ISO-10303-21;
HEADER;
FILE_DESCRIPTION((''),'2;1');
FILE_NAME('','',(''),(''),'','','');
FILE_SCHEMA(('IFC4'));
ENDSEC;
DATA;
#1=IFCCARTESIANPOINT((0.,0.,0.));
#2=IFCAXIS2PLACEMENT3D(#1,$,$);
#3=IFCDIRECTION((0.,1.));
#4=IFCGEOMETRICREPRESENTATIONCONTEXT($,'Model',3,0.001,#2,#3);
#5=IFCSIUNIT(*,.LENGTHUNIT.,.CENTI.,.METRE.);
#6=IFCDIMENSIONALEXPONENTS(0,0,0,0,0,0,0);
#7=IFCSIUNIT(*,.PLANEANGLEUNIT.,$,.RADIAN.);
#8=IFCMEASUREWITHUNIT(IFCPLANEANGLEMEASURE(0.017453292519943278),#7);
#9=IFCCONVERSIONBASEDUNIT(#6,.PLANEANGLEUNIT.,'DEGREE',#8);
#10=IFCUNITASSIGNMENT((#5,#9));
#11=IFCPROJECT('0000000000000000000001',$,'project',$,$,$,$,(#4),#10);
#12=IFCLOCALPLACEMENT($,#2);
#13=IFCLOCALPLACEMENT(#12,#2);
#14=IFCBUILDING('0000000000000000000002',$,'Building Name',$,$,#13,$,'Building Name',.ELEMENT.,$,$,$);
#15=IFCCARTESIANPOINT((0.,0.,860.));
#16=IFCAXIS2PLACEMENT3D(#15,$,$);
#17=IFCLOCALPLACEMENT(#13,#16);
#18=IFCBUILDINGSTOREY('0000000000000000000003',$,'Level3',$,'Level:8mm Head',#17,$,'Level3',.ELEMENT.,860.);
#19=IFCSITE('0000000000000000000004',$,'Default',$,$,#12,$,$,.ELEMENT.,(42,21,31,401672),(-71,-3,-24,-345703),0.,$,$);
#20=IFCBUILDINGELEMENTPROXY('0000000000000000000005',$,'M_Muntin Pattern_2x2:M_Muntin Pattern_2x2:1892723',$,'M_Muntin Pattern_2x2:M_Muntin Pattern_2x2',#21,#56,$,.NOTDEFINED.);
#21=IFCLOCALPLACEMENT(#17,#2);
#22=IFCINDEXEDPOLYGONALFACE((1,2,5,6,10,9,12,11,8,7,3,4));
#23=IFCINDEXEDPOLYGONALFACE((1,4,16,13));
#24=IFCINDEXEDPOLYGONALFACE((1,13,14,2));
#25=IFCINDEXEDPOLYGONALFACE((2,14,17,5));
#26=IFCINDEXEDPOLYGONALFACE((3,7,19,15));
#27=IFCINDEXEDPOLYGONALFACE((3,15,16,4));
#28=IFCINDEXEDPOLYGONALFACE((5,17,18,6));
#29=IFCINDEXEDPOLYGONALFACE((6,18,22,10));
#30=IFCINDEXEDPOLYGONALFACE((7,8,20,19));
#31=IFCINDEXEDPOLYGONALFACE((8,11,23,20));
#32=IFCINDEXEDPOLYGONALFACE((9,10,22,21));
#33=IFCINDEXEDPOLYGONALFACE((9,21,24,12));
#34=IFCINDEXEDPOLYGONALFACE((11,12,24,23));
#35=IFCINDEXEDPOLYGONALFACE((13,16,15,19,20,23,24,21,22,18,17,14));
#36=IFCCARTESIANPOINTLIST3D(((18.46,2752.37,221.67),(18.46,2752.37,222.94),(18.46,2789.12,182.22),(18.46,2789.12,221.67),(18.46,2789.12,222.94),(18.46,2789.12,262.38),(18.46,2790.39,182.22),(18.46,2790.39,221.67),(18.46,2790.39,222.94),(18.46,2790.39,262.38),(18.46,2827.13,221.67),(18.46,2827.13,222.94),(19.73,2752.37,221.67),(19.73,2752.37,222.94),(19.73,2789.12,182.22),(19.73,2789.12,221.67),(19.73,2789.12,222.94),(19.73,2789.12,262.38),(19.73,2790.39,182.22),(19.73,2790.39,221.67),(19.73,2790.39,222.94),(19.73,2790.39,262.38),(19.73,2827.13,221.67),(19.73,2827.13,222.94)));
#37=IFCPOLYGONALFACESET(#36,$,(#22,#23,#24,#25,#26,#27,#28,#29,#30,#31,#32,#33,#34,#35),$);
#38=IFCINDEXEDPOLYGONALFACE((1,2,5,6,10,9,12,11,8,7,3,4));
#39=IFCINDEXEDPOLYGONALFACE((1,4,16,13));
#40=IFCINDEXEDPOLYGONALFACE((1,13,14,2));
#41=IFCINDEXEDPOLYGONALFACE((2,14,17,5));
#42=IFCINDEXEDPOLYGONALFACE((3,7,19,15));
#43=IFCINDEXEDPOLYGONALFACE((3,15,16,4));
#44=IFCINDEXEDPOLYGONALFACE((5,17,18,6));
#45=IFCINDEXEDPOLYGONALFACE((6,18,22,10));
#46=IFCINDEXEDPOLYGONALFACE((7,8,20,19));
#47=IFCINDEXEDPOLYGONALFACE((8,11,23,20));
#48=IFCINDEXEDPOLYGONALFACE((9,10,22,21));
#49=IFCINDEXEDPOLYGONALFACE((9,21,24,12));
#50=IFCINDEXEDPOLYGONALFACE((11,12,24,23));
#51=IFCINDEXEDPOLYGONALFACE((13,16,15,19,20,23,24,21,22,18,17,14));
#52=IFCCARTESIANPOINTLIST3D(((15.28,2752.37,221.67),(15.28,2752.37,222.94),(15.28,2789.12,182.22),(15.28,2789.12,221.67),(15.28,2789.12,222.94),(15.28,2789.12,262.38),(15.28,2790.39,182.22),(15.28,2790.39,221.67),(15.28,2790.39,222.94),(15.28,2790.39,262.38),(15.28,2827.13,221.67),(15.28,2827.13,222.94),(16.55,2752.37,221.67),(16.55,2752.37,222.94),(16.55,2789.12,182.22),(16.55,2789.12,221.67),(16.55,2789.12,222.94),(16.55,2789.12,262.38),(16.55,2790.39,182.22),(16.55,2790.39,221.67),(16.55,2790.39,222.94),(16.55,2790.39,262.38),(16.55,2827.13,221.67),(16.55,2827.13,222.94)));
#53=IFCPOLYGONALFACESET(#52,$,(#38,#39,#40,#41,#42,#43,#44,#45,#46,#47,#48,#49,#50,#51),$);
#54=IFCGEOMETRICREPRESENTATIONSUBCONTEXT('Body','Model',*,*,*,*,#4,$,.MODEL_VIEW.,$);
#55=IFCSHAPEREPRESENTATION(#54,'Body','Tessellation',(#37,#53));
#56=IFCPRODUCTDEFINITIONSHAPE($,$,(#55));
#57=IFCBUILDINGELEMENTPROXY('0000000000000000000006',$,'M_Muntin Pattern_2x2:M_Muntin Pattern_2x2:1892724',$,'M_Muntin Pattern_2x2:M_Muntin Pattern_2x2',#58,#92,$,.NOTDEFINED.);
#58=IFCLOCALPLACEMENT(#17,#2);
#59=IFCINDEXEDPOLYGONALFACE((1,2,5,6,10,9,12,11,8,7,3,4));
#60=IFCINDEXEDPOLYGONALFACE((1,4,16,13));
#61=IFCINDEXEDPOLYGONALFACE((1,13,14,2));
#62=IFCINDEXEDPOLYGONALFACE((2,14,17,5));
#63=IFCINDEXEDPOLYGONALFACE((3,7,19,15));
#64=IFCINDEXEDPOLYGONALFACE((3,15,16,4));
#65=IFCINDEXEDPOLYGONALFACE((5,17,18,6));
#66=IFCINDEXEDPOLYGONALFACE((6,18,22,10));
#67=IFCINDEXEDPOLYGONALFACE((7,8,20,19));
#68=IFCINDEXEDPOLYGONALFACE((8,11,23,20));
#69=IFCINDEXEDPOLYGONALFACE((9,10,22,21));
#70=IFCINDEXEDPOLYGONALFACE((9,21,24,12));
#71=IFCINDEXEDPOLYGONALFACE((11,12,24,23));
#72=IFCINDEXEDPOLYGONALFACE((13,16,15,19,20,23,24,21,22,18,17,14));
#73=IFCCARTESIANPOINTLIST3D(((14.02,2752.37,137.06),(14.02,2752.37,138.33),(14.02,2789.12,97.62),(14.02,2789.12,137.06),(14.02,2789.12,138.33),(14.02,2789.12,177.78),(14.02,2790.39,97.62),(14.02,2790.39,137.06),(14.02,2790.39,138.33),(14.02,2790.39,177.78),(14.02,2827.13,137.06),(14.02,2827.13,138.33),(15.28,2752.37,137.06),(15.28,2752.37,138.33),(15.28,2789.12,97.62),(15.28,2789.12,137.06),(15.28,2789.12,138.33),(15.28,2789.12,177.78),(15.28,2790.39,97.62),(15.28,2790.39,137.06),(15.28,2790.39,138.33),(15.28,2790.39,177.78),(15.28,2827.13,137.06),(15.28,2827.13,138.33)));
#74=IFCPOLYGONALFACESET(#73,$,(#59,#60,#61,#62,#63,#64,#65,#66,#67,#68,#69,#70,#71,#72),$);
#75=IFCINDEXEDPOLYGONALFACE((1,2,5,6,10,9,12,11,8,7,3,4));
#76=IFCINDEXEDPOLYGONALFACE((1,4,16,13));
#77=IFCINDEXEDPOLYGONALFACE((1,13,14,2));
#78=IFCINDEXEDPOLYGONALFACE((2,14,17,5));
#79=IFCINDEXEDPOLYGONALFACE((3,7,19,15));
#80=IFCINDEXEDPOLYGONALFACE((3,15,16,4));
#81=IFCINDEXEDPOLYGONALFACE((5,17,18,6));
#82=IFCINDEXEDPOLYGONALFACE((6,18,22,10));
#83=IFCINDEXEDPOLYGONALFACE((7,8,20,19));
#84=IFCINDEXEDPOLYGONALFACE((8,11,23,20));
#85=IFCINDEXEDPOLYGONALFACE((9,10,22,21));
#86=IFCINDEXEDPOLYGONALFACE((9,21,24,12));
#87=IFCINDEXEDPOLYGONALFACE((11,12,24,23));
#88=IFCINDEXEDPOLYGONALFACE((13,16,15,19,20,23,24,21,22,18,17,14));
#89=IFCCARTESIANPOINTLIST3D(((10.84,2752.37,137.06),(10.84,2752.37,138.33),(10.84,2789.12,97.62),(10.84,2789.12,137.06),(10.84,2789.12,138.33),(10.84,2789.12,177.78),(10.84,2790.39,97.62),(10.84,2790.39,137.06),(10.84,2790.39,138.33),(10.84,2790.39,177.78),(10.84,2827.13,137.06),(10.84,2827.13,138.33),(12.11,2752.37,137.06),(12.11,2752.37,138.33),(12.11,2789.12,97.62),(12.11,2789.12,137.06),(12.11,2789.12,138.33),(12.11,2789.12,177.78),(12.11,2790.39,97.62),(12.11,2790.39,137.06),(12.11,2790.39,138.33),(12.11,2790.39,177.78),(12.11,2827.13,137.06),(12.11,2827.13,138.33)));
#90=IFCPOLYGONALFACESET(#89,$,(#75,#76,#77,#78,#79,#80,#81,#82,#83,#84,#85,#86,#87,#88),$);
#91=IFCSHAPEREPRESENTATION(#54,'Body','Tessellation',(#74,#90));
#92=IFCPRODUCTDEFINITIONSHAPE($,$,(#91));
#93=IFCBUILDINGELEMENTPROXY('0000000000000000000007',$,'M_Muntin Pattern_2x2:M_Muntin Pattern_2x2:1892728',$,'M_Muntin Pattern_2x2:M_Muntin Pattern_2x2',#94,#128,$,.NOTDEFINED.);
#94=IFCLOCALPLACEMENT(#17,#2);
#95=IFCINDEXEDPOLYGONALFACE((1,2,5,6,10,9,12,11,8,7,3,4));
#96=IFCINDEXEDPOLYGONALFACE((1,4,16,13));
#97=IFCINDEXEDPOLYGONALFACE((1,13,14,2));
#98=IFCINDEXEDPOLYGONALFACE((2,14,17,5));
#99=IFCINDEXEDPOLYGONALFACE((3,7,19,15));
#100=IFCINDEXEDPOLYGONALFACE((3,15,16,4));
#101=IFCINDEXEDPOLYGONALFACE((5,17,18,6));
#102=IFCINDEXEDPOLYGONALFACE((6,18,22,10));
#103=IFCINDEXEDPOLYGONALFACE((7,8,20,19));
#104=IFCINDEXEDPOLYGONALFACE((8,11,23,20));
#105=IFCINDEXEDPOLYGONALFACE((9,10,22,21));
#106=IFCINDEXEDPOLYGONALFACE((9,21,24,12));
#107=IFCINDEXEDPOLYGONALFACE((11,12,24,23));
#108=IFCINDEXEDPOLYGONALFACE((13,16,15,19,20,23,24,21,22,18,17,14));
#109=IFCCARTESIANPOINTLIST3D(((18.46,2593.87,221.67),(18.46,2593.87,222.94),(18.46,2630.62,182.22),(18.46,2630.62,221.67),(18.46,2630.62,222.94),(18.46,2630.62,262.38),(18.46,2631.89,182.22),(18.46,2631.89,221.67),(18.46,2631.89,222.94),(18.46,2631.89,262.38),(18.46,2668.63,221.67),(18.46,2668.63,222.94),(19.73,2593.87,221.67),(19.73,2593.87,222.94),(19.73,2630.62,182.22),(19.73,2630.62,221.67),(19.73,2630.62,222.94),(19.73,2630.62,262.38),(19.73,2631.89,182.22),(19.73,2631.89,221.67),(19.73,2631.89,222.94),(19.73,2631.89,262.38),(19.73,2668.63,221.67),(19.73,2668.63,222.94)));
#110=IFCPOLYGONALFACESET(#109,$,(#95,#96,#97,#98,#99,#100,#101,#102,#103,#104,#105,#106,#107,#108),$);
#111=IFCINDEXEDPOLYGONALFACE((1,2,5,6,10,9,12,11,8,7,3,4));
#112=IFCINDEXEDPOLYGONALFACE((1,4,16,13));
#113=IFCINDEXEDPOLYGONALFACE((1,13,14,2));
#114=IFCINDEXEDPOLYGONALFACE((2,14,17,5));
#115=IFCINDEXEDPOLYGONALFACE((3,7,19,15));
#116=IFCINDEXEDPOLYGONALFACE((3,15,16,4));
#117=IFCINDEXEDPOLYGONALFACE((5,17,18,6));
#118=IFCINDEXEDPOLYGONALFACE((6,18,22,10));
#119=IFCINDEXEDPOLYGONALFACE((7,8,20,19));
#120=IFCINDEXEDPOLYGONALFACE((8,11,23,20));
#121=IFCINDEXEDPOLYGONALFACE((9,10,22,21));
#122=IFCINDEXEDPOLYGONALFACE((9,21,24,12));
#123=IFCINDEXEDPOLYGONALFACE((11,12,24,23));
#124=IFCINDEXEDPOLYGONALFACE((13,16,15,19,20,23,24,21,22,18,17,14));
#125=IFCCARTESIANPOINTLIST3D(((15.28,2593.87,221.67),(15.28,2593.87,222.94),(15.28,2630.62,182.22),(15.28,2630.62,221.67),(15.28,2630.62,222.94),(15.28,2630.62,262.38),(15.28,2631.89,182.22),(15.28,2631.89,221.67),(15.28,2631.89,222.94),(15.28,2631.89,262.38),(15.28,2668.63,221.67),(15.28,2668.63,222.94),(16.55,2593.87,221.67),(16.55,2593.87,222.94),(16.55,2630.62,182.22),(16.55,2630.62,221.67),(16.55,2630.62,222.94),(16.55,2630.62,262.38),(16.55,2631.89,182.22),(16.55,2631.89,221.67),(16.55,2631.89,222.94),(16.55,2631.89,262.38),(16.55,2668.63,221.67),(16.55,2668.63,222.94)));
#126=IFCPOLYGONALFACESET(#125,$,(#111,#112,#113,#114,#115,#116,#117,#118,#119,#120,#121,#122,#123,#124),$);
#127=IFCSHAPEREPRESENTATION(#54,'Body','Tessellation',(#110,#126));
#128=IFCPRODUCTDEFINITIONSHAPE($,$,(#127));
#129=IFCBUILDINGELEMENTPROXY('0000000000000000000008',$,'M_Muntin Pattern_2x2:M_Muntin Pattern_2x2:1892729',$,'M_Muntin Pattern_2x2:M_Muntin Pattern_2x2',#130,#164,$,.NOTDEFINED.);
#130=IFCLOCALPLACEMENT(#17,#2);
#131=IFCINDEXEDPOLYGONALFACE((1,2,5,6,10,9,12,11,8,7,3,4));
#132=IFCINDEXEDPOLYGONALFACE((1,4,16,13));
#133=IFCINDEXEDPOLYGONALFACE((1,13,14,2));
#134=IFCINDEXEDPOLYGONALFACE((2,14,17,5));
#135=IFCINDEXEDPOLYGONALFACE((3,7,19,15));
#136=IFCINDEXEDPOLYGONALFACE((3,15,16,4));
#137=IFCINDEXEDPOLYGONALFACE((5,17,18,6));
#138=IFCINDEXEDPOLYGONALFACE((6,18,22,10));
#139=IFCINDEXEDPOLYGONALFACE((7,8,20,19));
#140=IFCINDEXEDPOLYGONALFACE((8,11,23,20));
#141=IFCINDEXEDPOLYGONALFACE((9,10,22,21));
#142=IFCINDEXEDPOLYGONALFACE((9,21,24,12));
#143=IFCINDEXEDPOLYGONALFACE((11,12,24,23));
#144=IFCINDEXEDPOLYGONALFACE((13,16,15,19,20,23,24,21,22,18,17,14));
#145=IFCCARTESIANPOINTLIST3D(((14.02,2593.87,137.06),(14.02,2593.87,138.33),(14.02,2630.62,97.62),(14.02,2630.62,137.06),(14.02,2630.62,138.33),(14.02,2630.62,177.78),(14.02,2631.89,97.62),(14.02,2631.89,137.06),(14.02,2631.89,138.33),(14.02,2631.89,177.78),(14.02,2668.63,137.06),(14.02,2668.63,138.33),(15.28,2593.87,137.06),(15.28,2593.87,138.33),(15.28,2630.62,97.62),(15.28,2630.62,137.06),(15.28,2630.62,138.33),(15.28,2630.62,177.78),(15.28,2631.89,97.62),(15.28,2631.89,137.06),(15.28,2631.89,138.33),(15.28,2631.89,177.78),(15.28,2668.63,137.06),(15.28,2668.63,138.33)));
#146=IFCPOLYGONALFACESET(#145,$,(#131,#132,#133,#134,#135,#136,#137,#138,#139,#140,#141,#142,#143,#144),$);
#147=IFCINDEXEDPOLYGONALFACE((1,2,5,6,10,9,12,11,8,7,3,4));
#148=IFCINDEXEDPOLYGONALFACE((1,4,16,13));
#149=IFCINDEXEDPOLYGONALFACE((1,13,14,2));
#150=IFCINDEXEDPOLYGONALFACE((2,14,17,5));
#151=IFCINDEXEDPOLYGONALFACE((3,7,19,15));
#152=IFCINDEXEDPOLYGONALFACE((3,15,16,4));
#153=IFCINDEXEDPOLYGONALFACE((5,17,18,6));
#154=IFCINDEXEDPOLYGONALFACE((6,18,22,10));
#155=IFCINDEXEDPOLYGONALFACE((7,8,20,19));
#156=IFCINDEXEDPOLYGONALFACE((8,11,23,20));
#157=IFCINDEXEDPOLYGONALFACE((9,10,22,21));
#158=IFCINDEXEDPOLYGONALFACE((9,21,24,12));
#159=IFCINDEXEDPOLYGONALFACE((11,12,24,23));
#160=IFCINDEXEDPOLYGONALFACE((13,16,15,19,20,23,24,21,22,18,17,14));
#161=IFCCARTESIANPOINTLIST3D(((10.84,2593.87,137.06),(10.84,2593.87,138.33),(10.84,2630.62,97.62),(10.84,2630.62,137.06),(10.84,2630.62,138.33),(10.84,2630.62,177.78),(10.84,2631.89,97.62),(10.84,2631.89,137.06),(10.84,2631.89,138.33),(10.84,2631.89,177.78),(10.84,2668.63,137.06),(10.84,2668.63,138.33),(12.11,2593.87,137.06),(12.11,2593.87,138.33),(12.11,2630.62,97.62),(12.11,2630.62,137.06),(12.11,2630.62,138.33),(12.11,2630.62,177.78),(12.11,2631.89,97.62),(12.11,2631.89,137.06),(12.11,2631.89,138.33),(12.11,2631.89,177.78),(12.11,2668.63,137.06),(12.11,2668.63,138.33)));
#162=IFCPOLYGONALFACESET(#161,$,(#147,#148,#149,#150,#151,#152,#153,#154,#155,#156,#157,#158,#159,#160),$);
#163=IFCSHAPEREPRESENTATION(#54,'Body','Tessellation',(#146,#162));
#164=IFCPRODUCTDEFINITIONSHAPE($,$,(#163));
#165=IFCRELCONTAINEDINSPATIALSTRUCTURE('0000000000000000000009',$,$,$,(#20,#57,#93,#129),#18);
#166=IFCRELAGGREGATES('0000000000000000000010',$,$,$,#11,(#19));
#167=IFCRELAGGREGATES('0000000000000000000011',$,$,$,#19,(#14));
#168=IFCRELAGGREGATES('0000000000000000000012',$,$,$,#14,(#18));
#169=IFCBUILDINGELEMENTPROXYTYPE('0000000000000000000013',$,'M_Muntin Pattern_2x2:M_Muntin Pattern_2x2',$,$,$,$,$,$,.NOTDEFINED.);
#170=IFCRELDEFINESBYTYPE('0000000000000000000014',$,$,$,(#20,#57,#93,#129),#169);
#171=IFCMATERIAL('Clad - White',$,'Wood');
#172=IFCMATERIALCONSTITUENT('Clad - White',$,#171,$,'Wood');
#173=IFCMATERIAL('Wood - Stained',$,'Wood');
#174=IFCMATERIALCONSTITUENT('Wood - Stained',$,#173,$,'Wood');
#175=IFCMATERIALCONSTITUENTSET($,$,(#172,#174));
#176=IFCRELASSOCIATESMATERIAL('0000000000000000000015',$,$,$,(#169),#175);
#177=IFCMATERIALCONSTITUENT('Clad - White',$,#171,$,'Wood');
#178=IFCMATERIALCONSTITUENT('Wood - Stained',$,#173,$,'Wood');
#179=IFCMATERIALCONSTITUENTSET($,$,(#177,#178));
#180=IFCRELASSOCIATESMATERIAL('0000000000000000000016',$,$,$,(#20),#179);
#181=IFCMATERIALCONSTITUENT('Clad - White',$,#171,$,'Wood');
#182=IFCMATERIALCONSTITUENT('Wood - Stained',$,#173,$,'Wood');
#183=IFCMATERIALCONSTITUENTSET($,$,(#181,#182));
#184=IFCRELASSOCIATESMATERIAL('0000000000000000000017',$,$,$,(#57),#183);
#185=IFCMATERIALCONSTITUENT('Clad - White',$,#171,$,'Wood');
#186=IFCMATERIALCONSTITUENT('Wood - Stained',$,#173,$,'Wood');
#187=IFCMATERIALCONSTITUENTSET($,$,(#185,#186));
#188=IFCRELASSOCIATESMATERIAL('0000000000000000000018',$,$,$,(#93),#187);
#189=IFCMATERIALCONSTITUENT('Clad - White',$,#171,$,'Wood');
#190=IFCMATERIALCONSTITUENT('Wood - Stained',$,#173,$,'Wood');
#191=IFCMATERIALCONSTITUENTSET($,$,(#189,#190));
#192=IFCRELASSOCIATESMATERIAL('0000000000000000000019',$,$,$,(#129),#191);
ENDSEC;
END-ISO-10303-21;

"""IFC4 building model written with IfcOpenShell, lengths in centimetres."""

from ifc_helpers import new_model, entity, si_unit, converted_unit, direction, frame, origin, place, context, subcontext, project, spatial, indexed_curve, outline, extrude, source, transform, mapped, material, constituent, constituent_set, type_object, type_shapes, element, save


model = new_model("IFC4")

# Units and contexts
model_context = context("Model", 3, precision=0.001, world=origin(), true_north=direction((0.0, 1.0)))
body_context = subcontext(model_context, "Body", "Model", "MODEL_VIEW")
ifc_project = project(units=[si_unit("LENGTHUNIT", "METRE", prefix="CENTI"), converted_unit("PLANEANGLEUNIT", "DEGREE", entity("IfcPlaneAngleMeasure", 0.017453292519943278), si_unit("PLANEANGLEUNIT", "RADIAN"), dimensions=[0, 0, 0, 0, 0, 0, 0])], contexts=[model_context])

# Site, building, storey
site_placement = place(None, origin())
site = spatial("IfcSite", under=ifc_project, at=site_placement, Name="Default", CompositionType="ELEMENT", RefLatitude=(42, 21, 31, 401672), RefLongitude=(-71, -3, -24, -345703), RefElevation=0.0)
building_placement = place(site_placement, origin())
building = spatial("IfcBuilding", under=site, at=building_placement, Name="Building Name", LongName="Building Name", CompositionType="ELEMENT")
storey_placement = place(building_placement, frame((0.0, 0.0, 860.0)))
storey = spatial("IfcBuildingStorey", under=building, at=storey_placement, Name="Level3", ObjectType="Level:8mm Head", LongName="Level3", CompositionType="ELEMENT", Elevation=860.0)

# Shared definitions
ifc_material_1 = material(Name="Wood - Stained", Category="Wood")

# Building element proxies
ifc_material_2 = material(Name="Clad - White", Category="Wood")
ifc_constituent_1 = constituent(ifc_material_2, Name="Clad - White", Category="Wood")
ifc_constituent_2 = constituent(ifc_material_1, Name="Wood - Stained", Category="Wood")
ifc_constituent_set_1 = constituent_set(constituents=[ifc_constituent_1, ifc_constituent_2])
ifc_constituent_3 = constituent(ifc_material_2, Name="Clad - White", Category="Wood")
ifc_constituent_4 = constituent(ifc_material_1, Name="Wood - Stained", Category="Wood")
ifc_constituent_set_2 = constituent_set(constituents=[ifc_constituent_3, ifc_constituent_4])
building_element_proxy_type_1 = type_object("IfcBuildingElementProxyType", Name="M_Muntin Pattern_2x2:M_Muntin Pattern_2x2", PredefinedType="NOTDEFINED", material=ifc_constituent_set_2)
shared_shape_1 = source(origin(), body_context, "Body", "SweptSolid", [
    extrude(outline(indexed_curve([(0.64, -0.64), (40.08, -0.64), (40.08, 0.63), (0.64, 0.63), (0.64, 37.38), (-0.63, 37.38), (-0.63, 0.63), (-40.08, 0.63), (-40.08, -0.64), (-0.63, -0.64), (-0.63, -37.38), (0.64, -37.38), (0.64, -0.64)], self_intersect=False)), frame((0.0, 0.95, 40.08), z_axis=(0.0, 1.0, 0.0), x_axis=(0.0, 0.0, 1.0)), (0.0, 0.0, 1.0), 1.27),
    extrude(outline(indexed_curve([(0.64, -0.64), (40.08, -0.64), (40.08, 0.63), (0.64, 0.63), (0.64, 37.38), (-0.63, 37.38), (-0.63, 0.63), (-40.08, 0.63), (-40.08, -0.64), (-0.63, -0.64), (-0.63, -37.38), (0.64, -37.38), (0.64, -0.64)], self_intersect=False)), frame((0.0, -2.22, 40.08), z_axis=(0.0, 1.0, 0.0), x_axis=(0.0, 0.0, 1.0)), (0.0, 0.0, 1.0), 1.27),
])
type_shapes(building_element_proxy_type_1, [shared_shape_1])
proxy_1_placement = place(storey_placement, frame((17.51, 2789.75, 182.22), z_axis=(0.0, 0.0, 1.0), x_axis=(0.0, -1.0, 0.0)))
element("IfcBuildingElementProxy", 1, at=proxy_1_placement, inside=storey, type_object=building_element_proxy_type_1, material=ifc_constituent_set_1, Name="M_Muntin Pattern_2x2:M_Muntin Pattern_2x2:1892723", ObjectType="M_Muntin Pattern_2x2:M_Muntin Pattern_2x2", PredefinedType="NOTDEFINED", context=body_context, shape_type="MappedRepresentation", body=[
    mapped(shared_shape_1, transform((0.0, 0.0, 0.0), scale=1.0)),
])
ifc_constituent_5 = constituent(ifc_material_2, Name="Clad - White", Category="Wood")
ifc_constituent_6 = constituent(ifc_material_1, Name="Wood - Stained", Category="Wood")
ifc_constituent_set_3 = constituent_set(constituents=[ifc_constituent_5, ifc_constituent_6])
proxy_2_placement = place(storey_placement, frame((13.06, 2789.75, 97.62), z_axis=(0.0, 0.0, 1.0), x_axis=(0.0, -1.0, 0.0)))
element("IfcBuildingElementProxy", 2, at=proxy_2_placement, inside=storey, type_object=building_element_proxy_type_1, material=ifc_constituent_set_3, Name="M_Muntin Pattern_2x2:M_Muntin Pattern_2x2:1892724", ObjectType="M_Muntin Pattern_2x2:M_Muntin Pattern_2x2", PredefinedType="NOTDEFINED", context=body_context, shape_type="MappedRepresentation", body=[
    mapped(shared_shape_1, transform((0.0, 0.0, 0.0), scale=1.0)),
])
ifc_constituent_7 = constituent(ifc_material_2, Name="Clad - White", Category="Wood")
ifc_constituent_8 = constituent(ifc_material_1, Name="Wood - Stained", Category="Wood")
ifc_constituent_set_4 = constituent_set(constituents=[ifc_constituent_7, ifc_constituent_8])
proxy_3_placement = place(storey_placement, frame((17.51, 2631.25, 182.22), z_axis=(0.0, 0.0, 1.0), x_axis=(0.0, -1.0, 0.0)))
element("IfcBuildingElementProxy", 3, at=proxy_3_placement, inside=storey, type_object=building_element_proxy_type_1, material=ifc_constituent_set_4, Name="M_Muntin Pattern_2x2:M_Muntin Pattern_2x2:1892728", ObjectType="M_Muntin Pattern_2x2:M_Muntin Pattern_2x2", PredefinedType="NOTDEFINED", context=body_context, shape_type="MappedRepresentation", body=[
    mapped(shared_shape_1, transform((0.0, 0.0, 0.0), scale=1.0)),
])
ifc_constituent_9 = constituent(ifc_material_2, Name="Clad - White", Category="Wood")
ifc_constituent_10 = constituent(ifc_material_1, Name="Wood - Stained", Category="Wood")
ifc_constituent_set_5 = constituent_set(constituents=[ifc_constituent_9, ifc_constituent_10])
proxy_4_placement = place(storey_placement, frame((13.06, 2631.25, 97.62), z_axis=(0.0, 0.0, 1.0), x_axis=(0.0, -1.0, 0.0)))
element("IfcBuildingElementProxy", 4, at=proxy_4_placement, inside=storey, type_object=building_element_proxy_type_1, material=ifc_constituent_set_5, Name="M_Muntin Pattern_2x2:M_Muntin Pattern_2x2:1892729", ObjectType="M_Muntin Pattern_2x2:M_Muntin Pattern_2x2", PredefinedType="NOTDEFINED", context=body_context, shape_type="MappedRepresentation", body=[
    mapped(shared_shape_1, transform((0.0, 0.0, 0.0), scale=1.0)),
])

save(model, "model.ifc")
